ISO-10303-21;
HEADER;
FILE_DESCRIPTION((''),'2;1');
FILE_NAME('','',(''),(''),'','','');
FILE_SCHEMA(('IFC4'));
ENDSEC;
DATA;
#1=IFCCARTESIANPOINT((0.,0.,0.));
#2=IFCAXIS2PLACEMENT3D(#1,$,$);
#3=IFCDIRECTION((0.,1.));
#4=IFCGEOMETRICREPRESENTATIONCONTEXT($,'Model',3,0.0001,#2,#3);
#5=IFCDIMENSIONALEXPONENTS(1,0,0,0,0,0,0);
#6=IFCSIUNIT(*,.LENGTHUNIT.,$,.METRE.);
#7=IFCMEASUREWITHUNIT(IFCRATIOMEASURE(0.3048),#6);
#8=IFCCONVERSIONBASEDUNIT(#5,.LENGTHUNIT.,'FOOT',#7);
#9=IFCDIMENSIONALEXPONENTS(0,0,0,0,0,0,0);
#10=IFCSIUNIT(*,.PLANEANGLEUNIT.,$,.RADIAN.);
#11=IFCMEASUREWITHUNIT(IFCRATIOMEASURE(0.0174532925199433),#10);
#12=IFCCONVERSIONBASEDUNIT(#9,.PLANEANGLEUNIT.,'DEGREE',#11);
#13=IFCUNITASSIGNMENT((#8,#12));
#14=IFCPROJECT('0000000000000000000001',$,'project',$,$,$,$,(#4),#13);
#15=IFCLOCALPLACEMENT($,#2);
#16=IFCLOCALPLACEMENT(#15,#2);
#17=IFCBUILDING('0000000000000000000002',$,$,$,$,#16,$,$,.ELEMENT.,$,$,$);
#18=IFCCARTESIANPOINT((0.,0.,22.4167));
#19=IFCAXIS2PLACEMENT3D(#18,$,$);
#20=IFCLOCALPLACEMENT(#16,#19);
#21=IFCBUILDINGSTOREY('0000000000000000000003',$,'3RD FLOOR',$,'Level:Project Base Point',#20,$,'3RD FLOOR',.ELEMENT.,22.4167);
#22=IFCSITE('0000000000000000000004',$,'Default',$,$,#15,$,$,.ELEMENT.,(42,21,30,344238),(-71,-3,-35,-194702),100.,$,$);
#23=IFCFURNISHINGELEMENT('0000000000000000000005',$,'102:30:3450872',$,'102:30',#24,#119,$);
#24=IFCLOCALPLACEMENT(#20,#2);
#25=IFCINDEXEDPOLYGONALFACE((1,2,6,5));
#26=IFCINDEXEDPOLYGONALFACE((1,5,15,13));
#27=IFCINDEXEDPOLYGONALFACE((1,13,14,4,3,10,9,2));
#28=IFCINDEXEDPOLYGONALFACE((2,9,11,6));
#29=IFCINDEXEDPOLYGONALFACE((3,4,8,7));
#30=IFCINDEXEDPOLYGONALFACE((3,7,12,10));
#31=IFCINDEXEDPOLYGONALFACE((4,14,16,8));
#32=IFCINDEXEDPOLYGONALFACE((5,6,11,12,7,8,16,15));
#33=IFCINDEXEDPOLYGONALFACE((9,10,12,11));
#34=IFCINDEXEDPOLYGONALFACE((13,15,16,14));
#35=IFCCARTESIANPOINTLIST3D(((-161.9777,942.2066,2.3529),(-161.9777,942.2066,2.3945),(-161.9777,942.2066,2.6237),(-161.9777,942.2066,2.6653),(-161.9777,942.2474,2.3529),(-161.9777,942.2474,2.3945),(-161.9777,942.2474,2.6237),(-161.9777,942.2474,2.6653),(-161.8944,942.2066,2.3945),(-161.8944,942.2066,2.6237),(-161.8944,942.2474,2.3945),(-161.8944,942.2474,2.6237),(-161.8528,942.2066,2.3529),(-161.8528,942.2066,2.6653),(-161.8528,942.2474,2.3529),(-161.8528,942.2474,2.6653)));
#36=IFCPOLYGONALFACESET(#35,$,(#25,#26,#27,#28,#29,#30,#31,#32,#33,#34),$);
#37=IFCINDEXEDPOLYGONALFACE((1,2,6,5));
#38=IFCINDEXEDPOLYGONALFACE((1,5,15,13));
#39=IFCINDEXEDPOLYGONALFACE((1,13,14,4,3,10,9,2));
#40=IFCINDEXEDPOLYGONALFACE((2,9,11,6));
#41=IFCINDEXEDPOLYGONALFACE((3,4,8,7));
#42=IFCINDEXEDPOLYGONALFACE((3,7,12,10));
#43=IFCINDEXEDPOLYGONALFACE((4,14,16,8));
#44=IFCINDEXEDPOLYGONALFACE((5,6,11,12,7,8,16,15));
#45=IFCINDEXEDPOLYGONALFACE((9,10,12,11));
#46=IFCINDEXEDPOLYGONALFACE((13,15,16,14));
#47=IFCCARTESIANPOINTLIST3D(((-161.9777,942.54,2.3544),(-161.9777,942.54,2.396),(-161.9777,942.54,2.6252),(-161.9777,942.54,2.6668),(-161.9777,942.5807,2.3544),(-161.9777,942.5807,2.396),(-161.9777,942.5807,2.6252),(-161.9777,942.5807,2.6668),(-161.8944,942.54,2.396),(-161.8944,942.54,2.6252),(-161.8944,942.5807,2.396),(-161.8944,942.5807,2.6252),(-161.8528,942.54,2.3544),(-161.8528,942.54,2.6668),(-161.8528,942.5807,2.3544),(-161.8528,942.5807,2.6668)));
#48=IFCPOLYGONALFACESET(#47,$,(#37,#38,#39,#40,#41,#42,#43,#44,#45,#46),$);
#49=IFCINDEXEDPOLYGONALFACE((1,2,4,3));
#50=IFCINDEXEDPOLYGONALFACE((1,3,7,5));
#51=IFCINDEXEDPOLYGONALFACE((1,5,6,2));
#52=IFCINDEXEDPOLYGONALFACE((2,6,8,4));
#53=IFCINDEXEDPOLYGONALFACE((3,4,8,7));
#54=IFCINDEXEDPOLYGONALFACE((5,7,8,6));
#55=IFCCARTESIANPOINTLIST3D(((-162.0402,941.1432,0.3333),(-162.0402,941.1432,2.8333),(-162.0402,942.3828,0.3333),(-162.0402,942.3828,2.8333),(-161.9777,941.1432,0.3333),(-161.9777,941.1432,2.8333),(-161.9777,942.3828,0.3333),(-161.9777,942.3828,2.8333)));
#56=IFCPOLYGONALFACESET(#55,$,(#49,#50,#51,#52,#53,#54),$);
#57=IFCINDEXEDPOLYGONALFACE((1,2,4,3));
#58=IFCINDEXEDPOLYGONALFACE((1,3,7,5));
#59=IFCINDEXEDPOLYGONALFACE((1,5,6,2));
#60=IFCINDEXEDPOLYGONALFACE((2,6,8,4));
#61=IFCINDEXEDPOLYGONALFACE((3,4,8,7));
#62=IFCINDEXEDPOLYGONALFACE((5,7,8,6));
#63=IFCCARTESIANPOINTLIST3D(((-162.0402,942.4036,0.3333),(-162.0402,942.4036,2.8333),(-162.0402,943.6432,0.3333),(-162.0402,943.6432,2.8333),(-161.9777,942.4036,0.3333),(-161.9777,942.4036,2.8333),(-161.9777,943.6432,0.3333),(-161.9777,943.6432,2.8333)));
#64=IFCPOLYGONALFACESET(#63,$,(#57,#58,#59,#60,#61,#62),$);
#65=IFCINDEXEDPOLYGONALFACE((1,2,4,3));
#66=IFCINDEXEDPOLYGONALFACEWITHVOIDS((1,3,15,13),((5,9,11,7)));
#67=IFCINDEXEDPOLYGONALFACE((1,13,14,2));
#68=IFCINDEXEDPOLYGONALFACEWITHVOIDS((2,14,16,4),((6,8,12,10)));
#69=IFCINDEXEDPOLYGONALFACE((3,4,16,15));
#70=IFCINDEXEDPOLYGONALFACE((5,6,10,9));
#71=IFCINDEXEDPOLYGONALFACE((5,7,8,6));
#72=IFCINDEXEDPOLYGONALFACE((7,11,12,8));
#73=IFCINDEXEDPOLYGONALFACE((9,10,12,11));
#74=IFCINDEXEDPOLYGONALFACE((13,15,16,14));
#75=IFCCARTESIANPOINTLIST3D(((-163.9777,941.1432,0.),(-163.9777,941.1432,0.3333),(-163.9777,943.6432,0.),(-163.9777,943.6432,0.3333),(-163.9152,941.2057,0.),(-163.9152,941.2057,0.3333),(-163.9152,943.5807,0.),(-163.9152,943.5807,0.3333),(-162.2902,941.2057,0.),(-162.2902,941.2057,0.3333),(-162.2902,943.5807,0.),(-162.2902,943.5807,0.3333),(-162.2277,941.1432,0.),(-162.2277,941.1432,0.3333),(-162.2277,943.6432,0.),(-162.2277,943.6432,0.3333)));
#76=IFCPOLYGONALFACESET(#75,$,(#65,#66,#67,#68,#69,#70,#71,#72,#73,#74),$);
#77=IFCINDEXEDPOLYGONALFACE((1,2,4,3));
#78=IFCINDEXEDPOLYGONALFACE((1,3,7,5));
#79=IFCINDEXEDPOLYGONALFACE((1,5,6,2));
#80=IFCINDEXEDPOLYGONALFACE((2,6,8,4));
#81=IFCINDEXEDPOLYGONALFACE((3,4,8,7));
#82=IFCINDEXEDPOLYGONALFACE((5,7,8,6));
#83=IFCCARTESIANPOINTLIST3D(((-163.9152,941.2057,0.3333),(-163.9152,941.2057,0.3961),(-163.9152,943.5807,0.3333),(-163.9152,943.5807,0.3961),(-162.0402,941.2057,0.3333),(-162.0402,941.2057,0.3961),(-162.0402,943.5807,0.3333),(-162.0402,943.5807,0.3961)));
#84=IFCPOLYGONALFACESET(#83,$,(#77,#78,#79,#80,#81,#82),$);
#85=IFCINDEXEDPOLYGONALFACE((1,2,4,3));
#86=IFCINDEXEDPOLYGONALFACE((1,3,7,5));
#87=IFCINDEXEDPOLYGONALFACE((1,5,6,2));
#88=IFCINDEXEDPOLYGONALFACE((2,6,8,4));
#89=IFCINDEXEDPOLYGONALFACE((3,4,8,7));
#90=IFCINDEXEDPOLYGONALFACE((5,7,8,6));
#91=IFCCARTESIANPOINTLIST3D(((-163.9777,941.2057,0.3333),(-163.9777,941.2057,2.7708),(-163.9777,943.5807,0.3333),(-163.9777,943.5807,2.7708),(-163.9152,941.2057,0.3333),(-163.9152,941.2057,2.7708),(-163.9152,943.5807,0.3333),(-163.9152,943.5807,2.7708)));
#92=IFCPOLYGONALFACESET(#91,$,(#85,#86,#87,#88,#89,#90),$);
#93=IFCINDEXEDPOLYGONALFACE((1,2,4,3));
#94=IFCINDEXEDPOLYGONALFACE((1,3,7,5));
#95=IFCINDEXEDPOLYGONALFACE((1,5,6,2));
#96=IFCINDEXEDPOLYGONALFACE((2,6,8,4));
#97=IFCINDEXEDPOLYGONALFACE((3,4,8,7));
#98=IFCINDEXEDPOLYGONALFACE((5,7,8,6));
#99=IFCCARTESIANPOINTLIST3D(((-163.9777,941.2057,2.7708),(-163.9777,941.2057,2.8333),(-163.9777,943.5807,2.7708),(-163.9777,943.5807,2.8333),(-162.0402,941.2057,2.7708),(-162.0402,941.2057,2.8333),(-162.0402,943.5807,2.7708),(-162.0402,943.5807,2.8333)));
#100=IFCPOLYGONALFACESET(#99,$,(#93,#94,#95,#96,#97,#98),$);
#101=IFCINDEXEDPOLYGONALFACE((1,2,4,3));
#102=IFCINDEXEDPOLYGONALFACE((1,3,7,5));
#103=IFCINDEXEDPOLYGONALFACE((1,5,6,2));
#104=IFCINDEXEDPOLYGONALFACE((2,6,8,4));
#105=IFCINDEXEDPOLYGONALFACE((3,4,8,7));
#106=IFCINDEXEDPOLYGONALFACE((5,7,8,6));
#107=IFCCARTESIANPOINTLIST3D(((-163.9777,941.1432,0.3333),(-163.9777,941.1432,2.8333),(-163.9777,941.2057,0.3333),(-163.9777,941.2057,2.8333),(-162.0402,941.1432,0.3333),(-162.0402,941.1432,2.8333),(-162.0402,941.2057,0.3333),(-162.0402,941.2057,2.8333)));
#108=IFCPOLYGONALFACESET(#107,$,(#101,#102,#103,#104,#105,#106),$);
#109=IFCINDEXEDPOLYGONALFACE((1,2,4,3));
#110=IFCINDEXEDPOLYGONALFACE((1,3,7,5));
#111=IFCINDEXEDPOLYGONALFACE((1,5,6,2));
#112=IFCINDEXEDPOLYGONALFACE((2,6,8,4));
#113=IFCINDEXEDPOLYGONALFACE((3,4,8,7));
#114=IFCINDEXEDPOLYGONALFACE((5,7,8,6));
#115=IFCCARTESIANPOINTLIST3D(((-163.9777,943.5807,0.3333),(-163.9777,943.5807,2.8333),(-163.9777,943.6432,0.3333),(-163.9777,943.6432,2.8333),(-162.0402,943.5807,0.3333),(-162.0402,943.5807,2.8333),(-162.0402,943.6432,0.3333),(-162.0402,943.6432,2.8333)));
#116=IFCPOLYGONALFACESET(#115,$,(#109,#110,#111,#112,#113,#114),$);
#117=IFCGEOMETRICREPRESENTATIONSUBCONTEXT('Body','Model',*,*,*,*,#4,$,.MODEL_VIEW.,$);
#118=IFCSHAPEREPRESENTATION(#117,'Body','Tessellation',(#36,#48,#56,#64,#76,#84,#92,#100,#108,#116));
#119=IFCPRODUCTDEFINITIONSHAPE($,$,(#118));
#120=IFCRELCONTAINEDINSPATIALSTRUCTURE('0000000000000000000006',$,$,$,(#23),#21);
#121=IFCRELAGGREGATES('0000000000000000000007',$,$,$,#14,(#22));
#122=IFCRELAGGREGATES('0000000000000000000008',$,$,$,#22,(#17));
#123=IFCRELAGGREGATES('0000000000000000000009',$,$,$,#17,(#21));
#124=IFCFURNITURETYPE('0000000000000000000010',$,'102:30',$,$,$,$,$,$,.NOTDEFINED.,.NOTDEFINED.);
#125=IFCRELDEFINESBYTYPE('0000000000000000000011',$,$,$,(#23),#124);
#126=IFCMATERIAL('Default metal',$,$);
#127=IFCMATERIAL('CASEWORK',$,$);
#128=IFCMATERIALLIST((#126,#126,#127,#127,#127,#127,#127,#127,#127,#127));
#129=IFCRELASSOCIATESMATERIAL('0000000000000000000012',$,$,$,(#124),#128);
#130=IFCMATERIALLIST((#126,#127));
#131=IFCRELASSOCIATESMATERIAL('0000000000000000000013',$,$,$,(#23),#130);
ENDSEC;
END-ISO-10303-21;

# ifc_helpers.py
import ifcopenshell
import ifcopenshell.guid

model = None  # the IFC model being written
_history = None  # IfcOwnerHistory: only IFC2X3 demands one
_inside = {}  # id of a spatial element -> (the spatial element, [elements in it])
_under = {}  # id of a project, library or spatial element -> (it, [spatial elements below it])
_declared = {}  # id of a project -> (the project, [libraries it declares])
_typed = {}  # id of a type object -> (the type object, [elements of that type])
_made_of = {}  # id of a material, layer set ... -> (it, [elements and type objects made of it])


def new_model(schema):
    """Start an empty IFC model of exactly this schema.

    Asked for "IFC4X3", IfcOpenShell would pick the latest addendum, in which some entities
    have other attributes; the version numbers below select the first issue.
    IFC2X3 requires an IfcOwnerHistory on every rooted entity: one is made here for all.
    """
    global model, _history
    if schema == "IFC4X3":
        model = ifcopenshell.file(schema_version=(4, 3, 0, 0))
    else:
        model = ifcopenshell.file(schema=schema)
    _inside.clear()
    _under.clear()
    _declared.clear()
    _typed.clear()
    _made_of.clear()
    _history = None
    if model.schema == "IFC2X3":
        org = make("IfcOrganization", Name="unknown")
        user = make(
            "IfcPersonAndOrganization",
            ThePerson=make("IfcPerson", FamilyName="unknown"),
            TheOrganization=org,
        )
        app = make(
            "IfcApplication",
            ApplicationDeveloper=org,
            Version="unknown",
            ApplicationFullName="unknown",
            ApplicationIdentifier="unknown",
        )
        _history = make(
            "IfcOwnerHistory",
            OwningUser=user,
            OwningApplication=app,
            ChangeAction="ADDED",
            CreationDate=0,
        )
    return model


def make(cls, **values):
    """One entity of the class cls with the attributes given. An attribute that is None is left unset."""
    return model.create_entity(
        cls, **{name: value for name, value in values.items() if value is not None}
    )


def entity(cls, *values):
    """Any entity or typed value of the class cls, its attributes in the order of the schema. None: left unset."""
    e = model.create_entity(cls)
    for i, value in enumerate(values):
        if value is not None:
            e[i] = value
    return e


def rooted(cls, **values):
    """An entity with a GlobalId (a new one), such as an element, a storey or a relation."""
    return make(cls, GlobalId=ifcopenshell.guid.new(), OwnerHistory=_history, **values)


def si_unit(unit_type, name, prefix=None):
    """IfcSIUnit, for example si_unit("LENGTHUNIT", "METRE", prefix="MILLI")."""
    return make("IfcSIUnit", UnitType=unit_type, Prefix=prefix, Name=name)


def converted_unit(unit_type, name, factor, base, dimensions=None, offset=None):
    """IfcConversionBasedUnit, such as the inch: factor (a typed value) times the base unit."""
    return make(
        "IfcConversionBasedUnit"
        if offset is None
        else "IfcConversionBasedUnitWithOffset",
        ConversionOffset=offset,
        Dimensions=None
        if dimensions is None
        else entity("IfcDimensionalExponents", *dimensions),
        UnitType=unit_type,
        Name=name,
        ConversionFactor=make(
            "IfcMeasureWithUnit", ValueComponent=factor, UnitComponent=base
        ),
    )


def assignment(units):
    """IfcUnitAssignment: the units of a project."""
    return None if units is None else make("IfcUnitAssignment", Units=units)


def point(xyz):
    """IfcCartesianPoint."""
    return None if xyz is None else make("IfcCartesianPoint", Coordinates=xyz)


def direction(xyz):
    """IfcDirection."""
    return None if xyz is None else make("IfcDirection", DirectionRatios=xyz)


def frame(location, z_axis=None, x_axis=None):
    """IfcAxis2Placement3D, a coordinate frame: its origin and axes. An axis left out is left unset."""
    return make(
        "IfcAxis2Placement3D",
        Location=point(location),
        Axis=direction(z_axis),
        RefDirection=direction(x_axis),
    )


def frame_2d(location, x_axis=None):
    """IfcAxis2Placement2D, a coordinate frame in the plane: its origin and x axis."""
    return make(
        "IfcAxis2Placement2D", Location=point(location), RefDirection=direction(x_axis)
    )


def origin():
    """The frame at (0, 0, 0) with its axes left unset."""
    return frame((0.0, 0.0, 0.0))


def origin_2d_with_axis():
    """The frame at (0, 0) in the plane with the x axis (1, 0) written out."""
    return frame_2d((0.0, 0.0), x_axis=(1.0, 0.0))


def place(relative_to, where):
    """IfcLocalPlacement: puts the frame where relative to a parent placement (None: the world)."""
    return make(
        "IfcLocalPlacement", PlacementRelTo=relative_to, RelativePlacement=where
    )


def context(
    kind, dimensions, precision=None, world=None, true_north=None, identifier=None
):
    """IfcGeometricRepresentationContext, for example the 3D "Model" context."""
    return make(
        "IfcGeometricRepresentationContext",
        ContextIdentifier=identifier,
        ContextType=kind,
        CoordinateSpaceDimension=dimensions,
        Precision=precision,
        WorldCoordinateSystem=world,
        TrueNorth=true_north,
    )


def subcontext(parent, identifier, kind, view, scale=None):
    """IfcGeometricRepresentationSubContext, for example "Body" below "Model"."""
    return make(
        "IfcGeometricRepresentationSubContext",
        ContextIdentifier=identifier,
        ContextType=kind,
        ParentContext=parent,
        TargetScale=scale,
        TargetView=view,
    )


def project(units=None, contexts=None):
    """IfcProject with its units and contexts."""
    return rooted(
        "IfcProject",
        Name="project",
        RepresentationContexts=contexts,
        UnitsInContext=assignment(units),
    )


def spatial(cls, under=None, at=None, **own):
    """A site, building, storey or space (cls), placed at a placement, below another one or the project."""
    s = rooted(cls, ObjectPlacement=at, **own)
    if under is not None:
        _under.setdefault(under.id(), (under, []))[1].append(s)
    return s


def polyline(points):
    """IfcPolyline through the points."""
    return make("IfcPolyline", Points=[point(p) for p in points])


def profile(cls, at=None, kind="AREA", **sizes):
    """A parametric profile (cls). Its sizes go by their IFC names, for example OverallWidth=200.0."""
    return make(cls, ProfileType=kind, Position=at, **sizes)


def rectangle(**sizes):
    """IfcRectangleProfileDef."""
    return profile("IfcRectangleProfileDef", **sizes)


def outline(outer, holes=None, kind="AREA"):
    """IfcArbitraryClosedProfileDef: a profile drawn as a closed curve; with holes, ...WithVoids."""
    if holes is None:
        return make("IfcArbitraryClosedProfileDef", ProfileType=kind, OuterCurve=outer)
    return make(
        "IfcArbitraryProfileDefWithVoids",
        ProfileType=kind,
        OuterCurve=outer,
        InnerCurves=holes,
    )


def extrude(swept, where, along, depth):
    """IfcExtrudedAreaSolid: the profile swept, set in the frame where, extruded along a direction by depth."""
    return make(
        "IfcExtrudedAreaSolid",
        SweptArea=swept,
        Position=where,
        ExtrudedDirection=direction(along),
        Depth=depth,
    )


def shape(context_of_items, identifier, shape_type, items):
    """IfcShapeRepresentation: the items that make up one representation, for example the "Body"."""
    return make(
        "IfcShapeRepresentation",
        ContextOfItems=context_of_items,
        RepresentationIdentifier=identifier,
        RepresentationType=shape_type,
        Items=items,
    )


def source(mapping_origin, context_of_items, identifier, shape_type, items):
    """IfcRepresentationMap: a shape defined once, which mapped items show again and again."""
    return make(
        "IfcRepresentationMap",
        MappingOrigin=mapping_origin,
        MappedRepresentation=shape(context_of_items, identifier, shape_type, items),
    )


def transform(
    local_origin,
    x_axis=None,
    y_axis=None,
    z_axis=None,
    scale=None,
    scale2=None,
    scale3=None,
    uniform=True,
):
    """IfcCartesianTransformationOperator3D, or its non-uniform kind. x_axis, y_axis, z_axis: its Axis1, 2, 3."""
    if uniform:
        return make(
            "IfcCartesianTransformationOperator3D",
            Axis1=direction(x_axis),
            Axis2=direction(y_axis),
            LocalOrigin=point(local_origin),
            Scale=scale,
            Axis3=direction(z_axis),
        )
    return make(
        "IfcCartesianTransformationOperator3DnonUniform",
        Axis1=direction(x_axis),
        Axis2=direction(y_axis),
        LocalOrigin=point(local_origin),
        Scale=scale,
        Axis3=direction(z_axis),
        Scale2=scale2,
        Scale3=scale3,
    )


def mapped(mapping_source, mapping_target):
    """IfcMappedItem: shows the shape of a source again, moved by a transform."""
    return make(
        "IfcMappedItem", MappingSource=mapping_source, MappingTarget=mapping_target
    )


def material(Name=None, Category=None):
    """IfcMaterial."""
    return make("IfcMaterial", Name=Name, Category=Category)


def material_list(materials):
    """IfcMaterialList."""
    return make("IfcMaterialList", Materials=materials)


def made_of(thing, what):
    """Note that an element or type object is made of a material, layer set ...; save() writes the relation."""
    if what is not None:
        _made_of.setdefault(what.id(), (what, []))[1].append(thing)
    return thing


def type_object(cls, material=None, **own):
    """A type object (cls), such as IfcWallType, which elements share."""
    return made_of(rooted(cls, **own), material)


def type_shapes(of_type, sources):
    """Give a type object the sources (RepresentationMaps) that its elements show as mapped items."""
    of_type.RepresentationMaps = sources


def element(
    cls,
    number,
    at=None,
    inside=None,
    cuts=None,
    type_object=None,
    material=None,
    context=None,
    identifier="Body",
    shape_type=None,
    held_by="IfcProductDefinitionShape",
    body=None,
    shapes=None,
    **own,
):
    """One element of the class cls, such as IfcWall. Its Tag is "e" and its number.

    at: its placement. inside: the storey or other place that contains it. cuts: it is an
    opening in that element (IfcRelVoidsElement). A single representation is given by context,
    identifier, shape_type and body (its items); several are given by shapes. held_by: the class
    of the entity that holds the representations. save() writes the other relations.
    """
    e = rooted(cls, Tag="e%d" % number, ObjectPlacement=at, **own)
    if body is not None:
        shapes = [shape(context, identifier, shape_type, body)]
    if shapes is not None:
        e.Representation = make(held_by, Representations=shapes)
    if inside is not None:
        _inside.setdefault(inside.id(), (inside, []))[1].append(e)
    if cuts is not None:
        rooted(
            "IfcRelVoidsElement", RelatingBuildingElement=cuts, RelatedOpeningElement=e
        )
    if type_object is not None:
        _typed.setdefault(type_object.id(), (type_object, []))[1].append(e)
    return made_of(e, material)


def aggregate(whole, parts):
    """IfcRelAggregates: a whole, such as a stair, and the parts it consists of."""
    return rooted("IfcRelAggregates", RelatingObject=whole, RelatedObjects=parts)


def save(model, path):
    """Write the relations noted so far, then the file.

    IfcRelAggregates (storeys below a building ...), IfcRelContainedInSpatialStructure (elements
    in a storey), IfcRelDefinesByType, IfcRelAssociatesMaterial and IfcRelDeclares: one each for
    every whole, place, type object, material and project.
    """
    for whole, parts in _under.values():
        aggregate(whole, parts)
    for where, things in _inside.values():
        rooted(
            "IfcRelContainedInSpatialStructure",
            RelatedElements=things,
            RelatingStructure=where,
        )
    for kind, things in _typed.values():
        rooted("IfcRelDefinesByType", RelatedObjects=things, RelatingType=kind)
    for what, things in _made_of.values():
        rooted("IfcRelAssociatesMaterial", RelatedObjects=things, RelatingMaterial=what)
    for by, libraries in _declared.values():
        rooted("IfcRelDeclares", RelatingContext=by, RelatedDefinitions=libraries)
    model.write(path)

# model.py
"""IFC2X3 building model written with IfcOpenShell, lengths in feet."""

from ifc_helpers import new_model, entity, si_unit, converted_unit, direction, frame, frame_2d, origin, origin_2d_with_axis, place, context, subcontext, project, spatial, polyline, rectangle, outline, extrude, source, transform, mapped, material, material_list, type_object, type_shapes, element, save


model = new_model("IFC2X3")

# Units and contexts
model_context = context("Model", 3, precision=0.0001, world=origin(), true_north=direction((0.0, 1.0)))
body_context = subcontext(model_context, "Body", "Model", "MODEL_VIEW")
ifc_project = project(units=[converted_unit("LENGTHUNIT", "FOOT", entity("IfcRatioMeasure", 0.3048), si_unit("LENGTHUNIT", "METRE"), dimensions=[1, 0, 0, 0, 0, 0, 0]), converted_unit("PLANEANGLEUNIT", "DEGREE", entity("IfcRatioMeasure", 0.0174532925199433), si_unit("PLANEANGLEUNIT", "RADIAN"), dimensions=[0, 0, 0, 0, 0, 0, 0])], contexts=[model_context])

# Site, building, storey
site_placement = place(None, origin())
site = spatial("IfcSite", under=ifc_project, at=site_placement, Name="Default", CompositionType="ELEMENT", RefLatitude=(42, 21, 30, 344238), RefLongitude=(-71, -3, -35, -194702), RefElevation=100.0)
building_placement = place(site_placement, origin())
building = spatial("IfcBuilding", under=site, at=building_placement, CompositionType="ELEMENT")
storey_placement = place(building_placement, frame((0.0, 0.0, 22.4167)))
storey = spatial("IfcBuildingStorey", under=building, at=storey_placement, Name="3RD FLOOR", ObjectType="Level:Project Base Point", LongName="3RD FLOOR", CompositionType="ELEMENT", Elevation=22.4167)

# Furnishing element
ifc_material_1 = material(Name="CASEWORK")
ifc_material_2 = material(Name="Default metal")
ifc_material_list_1 = material_list([ifc_material_2, ifc_material_1])
ifc_material_list_2 = material_list([ifc_material_2, ifc_material_2, ifc_material_1, ifc_material_1, ifc_material_1, ifc_material_1, ifc_material_1, ifc_material_1, ifc_material_1, ifc_material_1])
furniture_type_1 = type_object("IfcFurnitureType", Name="102:30", material=ifc_material_list_2)
shared_shape_1 = source(origin(), body_context, "Body", "SweptSolid", [
    extrude(outline(polyline([(-0.0521, -0.1146), (-0.0521, -0.1562), (0.0729, -0.1562), (0.0729, 0.1562), (-0.0521, 0.1562), (-0.0521, 0.1146), (0.0313, 0.1146), (0.0313, -0.1146), (-0.0521, -0.1146)])), frame((0.2073, 2.0521, 2.5091), z_axis=(-1.0, 0.0, 0.0), x_axis=(0.0, 1.0, 0.0)), (0.0, 0.0, -1.0), 0.0407),
    extrude(outline(polyline([(-0.0521, -0.1146), (-0.0521, -0.1562), (0.0729, -0.1562), (0.0729, 0.1562), (-0.0521, 0.1562), (-0.0521, 0.1146), (0.0313, 0.1146), (0.0313, -0.1146), (-0.0521, -0.1146)])), frame((-0.126, 2.0521, 2.5106), z_axis=(-1.0, 0.0, 0.0), x_axis=(0.0, 1.0, 0.0)), (0.0, 0.0, -1.0), 0.0407),
    extrude(rectangle(XDim=1.2396, YDim=0.0625, at=frame_2d((0.0, 0.0), x_axis=(1.0, 0.0))), frame((0.6917, 1.9688, 0.3333), z_axis=(0.0, 0.0, 1.0), x_axis=(-1.0, 0.0, 0.0)), (0.0, 0.0, 1.0), 2.5),
    extrude(rectangle(XDim=1.2396, YDim=0.0625, at=origin_2d_with_axis()), frame((-0.5687, 1.9688, 0.3333), z_axis=(0.0, 0.0, 1.0), x_axis=(-1.0, 0.0, 0.0)), (0.0, 0.0, 1.0), 2.5),
    extrude(outline(polyline([(-0.875, -1.25), (0.875, -1.25), (0.875, 1.25), (-0.875, 1.25), (-0.875, -1.25)]), holes=[polyline([(-0.8125, -1.1875), (-0.8125, 1.1875), (0.8125, 1.1875), (0.8125, -1.1875), (-0.8125, -1.1875)])]), frame((0.0615, 0.875, 0.0), z_axis=(0.0, 0.0, 1.0), x_axis=(0.0, -1.0, 0.0)), (0.0, 0.0, 1.0), 0.3333),
    extrude(rectangle(XDim=1.875, YDim=2.375, at=origin_2d_with_axis()), frame((0.0615, 1.0, 0.3333), z_axis=(0.0, 0.0, 1.0), x_axis=(0.0, 1.0, 0.0)), (0.0, 0.0, 1.0), 0.0627),
    extrude(rectangle(XDim=2.375, YDim=0.0625, at=origin_2d_with_axis()), frame((0.0615, 0.0312, 0.3333), z_axis=(0.0, 0.0, 1.0), x_axis=(-1.0, 0.0, 0.0)), (0.0, 0.0, 1.0), 2.4375),
    extrude(rectangle(XDim=1.9375, YDim=2.375, at=frame_2d((0.0, 0.0), x_axis=(1.0, 0.0))), frame((0.0615, 0.9688, 2.7708), z_axis=(0.0, 0.0, 1.0), x_axis=(0.0, 1.0, 0.0)), (0.0, 0.0, 1.0), 0.0625),
    extrude(rectangle(XDim=1.9375, YDim=0.0625, at=frame_2d((0.0, 0.0), x_axis=(1.0, 0.0))), frame((1.2802, 0.9687, 0.3333), z_axis=(0.0, 0.0, 1.0), x_axis=(0.0, -1.0, 0.0)), (0.0, 0.0, 1.0), 2.5),
    extrude(rectangle(XDim=1.9375, YDim=0.0625, at=frame_2d((0.0, 0.0), x_axis=(1.0, 0.0))), frame((-1.1573, 0.9687, 0.3333), z_axis=(0.0, 0.0, 1.0), x_axis=(0.0, -1.0, 0.0)), (0.0, 0.0, 1.0), 2.5),
])
type_shapes(furniture_type_1, [shared_shape_1])
furnishing_1_placement = place(storey_placement, frame((-163.9777, 942.4547, 0.0), z_axis=(0.0, 0.0, 1.0), x_axis=(0.0, -1.0, 0.0)))
element("IfcFurnishingElement", 1, at=furnishing_1_placement, inside=storey, type_object=furniture_type_1, material=ifc_material_list_1, Name="102:30:3450872", ObjectType="102:30", context=body_context, shape_type="MappedRepresentation", body=[
    mapped(shared_shape_1, transform((0.0, 0.0, 0.0), scale=1.0)),
])

save(model, "model.ifc")
